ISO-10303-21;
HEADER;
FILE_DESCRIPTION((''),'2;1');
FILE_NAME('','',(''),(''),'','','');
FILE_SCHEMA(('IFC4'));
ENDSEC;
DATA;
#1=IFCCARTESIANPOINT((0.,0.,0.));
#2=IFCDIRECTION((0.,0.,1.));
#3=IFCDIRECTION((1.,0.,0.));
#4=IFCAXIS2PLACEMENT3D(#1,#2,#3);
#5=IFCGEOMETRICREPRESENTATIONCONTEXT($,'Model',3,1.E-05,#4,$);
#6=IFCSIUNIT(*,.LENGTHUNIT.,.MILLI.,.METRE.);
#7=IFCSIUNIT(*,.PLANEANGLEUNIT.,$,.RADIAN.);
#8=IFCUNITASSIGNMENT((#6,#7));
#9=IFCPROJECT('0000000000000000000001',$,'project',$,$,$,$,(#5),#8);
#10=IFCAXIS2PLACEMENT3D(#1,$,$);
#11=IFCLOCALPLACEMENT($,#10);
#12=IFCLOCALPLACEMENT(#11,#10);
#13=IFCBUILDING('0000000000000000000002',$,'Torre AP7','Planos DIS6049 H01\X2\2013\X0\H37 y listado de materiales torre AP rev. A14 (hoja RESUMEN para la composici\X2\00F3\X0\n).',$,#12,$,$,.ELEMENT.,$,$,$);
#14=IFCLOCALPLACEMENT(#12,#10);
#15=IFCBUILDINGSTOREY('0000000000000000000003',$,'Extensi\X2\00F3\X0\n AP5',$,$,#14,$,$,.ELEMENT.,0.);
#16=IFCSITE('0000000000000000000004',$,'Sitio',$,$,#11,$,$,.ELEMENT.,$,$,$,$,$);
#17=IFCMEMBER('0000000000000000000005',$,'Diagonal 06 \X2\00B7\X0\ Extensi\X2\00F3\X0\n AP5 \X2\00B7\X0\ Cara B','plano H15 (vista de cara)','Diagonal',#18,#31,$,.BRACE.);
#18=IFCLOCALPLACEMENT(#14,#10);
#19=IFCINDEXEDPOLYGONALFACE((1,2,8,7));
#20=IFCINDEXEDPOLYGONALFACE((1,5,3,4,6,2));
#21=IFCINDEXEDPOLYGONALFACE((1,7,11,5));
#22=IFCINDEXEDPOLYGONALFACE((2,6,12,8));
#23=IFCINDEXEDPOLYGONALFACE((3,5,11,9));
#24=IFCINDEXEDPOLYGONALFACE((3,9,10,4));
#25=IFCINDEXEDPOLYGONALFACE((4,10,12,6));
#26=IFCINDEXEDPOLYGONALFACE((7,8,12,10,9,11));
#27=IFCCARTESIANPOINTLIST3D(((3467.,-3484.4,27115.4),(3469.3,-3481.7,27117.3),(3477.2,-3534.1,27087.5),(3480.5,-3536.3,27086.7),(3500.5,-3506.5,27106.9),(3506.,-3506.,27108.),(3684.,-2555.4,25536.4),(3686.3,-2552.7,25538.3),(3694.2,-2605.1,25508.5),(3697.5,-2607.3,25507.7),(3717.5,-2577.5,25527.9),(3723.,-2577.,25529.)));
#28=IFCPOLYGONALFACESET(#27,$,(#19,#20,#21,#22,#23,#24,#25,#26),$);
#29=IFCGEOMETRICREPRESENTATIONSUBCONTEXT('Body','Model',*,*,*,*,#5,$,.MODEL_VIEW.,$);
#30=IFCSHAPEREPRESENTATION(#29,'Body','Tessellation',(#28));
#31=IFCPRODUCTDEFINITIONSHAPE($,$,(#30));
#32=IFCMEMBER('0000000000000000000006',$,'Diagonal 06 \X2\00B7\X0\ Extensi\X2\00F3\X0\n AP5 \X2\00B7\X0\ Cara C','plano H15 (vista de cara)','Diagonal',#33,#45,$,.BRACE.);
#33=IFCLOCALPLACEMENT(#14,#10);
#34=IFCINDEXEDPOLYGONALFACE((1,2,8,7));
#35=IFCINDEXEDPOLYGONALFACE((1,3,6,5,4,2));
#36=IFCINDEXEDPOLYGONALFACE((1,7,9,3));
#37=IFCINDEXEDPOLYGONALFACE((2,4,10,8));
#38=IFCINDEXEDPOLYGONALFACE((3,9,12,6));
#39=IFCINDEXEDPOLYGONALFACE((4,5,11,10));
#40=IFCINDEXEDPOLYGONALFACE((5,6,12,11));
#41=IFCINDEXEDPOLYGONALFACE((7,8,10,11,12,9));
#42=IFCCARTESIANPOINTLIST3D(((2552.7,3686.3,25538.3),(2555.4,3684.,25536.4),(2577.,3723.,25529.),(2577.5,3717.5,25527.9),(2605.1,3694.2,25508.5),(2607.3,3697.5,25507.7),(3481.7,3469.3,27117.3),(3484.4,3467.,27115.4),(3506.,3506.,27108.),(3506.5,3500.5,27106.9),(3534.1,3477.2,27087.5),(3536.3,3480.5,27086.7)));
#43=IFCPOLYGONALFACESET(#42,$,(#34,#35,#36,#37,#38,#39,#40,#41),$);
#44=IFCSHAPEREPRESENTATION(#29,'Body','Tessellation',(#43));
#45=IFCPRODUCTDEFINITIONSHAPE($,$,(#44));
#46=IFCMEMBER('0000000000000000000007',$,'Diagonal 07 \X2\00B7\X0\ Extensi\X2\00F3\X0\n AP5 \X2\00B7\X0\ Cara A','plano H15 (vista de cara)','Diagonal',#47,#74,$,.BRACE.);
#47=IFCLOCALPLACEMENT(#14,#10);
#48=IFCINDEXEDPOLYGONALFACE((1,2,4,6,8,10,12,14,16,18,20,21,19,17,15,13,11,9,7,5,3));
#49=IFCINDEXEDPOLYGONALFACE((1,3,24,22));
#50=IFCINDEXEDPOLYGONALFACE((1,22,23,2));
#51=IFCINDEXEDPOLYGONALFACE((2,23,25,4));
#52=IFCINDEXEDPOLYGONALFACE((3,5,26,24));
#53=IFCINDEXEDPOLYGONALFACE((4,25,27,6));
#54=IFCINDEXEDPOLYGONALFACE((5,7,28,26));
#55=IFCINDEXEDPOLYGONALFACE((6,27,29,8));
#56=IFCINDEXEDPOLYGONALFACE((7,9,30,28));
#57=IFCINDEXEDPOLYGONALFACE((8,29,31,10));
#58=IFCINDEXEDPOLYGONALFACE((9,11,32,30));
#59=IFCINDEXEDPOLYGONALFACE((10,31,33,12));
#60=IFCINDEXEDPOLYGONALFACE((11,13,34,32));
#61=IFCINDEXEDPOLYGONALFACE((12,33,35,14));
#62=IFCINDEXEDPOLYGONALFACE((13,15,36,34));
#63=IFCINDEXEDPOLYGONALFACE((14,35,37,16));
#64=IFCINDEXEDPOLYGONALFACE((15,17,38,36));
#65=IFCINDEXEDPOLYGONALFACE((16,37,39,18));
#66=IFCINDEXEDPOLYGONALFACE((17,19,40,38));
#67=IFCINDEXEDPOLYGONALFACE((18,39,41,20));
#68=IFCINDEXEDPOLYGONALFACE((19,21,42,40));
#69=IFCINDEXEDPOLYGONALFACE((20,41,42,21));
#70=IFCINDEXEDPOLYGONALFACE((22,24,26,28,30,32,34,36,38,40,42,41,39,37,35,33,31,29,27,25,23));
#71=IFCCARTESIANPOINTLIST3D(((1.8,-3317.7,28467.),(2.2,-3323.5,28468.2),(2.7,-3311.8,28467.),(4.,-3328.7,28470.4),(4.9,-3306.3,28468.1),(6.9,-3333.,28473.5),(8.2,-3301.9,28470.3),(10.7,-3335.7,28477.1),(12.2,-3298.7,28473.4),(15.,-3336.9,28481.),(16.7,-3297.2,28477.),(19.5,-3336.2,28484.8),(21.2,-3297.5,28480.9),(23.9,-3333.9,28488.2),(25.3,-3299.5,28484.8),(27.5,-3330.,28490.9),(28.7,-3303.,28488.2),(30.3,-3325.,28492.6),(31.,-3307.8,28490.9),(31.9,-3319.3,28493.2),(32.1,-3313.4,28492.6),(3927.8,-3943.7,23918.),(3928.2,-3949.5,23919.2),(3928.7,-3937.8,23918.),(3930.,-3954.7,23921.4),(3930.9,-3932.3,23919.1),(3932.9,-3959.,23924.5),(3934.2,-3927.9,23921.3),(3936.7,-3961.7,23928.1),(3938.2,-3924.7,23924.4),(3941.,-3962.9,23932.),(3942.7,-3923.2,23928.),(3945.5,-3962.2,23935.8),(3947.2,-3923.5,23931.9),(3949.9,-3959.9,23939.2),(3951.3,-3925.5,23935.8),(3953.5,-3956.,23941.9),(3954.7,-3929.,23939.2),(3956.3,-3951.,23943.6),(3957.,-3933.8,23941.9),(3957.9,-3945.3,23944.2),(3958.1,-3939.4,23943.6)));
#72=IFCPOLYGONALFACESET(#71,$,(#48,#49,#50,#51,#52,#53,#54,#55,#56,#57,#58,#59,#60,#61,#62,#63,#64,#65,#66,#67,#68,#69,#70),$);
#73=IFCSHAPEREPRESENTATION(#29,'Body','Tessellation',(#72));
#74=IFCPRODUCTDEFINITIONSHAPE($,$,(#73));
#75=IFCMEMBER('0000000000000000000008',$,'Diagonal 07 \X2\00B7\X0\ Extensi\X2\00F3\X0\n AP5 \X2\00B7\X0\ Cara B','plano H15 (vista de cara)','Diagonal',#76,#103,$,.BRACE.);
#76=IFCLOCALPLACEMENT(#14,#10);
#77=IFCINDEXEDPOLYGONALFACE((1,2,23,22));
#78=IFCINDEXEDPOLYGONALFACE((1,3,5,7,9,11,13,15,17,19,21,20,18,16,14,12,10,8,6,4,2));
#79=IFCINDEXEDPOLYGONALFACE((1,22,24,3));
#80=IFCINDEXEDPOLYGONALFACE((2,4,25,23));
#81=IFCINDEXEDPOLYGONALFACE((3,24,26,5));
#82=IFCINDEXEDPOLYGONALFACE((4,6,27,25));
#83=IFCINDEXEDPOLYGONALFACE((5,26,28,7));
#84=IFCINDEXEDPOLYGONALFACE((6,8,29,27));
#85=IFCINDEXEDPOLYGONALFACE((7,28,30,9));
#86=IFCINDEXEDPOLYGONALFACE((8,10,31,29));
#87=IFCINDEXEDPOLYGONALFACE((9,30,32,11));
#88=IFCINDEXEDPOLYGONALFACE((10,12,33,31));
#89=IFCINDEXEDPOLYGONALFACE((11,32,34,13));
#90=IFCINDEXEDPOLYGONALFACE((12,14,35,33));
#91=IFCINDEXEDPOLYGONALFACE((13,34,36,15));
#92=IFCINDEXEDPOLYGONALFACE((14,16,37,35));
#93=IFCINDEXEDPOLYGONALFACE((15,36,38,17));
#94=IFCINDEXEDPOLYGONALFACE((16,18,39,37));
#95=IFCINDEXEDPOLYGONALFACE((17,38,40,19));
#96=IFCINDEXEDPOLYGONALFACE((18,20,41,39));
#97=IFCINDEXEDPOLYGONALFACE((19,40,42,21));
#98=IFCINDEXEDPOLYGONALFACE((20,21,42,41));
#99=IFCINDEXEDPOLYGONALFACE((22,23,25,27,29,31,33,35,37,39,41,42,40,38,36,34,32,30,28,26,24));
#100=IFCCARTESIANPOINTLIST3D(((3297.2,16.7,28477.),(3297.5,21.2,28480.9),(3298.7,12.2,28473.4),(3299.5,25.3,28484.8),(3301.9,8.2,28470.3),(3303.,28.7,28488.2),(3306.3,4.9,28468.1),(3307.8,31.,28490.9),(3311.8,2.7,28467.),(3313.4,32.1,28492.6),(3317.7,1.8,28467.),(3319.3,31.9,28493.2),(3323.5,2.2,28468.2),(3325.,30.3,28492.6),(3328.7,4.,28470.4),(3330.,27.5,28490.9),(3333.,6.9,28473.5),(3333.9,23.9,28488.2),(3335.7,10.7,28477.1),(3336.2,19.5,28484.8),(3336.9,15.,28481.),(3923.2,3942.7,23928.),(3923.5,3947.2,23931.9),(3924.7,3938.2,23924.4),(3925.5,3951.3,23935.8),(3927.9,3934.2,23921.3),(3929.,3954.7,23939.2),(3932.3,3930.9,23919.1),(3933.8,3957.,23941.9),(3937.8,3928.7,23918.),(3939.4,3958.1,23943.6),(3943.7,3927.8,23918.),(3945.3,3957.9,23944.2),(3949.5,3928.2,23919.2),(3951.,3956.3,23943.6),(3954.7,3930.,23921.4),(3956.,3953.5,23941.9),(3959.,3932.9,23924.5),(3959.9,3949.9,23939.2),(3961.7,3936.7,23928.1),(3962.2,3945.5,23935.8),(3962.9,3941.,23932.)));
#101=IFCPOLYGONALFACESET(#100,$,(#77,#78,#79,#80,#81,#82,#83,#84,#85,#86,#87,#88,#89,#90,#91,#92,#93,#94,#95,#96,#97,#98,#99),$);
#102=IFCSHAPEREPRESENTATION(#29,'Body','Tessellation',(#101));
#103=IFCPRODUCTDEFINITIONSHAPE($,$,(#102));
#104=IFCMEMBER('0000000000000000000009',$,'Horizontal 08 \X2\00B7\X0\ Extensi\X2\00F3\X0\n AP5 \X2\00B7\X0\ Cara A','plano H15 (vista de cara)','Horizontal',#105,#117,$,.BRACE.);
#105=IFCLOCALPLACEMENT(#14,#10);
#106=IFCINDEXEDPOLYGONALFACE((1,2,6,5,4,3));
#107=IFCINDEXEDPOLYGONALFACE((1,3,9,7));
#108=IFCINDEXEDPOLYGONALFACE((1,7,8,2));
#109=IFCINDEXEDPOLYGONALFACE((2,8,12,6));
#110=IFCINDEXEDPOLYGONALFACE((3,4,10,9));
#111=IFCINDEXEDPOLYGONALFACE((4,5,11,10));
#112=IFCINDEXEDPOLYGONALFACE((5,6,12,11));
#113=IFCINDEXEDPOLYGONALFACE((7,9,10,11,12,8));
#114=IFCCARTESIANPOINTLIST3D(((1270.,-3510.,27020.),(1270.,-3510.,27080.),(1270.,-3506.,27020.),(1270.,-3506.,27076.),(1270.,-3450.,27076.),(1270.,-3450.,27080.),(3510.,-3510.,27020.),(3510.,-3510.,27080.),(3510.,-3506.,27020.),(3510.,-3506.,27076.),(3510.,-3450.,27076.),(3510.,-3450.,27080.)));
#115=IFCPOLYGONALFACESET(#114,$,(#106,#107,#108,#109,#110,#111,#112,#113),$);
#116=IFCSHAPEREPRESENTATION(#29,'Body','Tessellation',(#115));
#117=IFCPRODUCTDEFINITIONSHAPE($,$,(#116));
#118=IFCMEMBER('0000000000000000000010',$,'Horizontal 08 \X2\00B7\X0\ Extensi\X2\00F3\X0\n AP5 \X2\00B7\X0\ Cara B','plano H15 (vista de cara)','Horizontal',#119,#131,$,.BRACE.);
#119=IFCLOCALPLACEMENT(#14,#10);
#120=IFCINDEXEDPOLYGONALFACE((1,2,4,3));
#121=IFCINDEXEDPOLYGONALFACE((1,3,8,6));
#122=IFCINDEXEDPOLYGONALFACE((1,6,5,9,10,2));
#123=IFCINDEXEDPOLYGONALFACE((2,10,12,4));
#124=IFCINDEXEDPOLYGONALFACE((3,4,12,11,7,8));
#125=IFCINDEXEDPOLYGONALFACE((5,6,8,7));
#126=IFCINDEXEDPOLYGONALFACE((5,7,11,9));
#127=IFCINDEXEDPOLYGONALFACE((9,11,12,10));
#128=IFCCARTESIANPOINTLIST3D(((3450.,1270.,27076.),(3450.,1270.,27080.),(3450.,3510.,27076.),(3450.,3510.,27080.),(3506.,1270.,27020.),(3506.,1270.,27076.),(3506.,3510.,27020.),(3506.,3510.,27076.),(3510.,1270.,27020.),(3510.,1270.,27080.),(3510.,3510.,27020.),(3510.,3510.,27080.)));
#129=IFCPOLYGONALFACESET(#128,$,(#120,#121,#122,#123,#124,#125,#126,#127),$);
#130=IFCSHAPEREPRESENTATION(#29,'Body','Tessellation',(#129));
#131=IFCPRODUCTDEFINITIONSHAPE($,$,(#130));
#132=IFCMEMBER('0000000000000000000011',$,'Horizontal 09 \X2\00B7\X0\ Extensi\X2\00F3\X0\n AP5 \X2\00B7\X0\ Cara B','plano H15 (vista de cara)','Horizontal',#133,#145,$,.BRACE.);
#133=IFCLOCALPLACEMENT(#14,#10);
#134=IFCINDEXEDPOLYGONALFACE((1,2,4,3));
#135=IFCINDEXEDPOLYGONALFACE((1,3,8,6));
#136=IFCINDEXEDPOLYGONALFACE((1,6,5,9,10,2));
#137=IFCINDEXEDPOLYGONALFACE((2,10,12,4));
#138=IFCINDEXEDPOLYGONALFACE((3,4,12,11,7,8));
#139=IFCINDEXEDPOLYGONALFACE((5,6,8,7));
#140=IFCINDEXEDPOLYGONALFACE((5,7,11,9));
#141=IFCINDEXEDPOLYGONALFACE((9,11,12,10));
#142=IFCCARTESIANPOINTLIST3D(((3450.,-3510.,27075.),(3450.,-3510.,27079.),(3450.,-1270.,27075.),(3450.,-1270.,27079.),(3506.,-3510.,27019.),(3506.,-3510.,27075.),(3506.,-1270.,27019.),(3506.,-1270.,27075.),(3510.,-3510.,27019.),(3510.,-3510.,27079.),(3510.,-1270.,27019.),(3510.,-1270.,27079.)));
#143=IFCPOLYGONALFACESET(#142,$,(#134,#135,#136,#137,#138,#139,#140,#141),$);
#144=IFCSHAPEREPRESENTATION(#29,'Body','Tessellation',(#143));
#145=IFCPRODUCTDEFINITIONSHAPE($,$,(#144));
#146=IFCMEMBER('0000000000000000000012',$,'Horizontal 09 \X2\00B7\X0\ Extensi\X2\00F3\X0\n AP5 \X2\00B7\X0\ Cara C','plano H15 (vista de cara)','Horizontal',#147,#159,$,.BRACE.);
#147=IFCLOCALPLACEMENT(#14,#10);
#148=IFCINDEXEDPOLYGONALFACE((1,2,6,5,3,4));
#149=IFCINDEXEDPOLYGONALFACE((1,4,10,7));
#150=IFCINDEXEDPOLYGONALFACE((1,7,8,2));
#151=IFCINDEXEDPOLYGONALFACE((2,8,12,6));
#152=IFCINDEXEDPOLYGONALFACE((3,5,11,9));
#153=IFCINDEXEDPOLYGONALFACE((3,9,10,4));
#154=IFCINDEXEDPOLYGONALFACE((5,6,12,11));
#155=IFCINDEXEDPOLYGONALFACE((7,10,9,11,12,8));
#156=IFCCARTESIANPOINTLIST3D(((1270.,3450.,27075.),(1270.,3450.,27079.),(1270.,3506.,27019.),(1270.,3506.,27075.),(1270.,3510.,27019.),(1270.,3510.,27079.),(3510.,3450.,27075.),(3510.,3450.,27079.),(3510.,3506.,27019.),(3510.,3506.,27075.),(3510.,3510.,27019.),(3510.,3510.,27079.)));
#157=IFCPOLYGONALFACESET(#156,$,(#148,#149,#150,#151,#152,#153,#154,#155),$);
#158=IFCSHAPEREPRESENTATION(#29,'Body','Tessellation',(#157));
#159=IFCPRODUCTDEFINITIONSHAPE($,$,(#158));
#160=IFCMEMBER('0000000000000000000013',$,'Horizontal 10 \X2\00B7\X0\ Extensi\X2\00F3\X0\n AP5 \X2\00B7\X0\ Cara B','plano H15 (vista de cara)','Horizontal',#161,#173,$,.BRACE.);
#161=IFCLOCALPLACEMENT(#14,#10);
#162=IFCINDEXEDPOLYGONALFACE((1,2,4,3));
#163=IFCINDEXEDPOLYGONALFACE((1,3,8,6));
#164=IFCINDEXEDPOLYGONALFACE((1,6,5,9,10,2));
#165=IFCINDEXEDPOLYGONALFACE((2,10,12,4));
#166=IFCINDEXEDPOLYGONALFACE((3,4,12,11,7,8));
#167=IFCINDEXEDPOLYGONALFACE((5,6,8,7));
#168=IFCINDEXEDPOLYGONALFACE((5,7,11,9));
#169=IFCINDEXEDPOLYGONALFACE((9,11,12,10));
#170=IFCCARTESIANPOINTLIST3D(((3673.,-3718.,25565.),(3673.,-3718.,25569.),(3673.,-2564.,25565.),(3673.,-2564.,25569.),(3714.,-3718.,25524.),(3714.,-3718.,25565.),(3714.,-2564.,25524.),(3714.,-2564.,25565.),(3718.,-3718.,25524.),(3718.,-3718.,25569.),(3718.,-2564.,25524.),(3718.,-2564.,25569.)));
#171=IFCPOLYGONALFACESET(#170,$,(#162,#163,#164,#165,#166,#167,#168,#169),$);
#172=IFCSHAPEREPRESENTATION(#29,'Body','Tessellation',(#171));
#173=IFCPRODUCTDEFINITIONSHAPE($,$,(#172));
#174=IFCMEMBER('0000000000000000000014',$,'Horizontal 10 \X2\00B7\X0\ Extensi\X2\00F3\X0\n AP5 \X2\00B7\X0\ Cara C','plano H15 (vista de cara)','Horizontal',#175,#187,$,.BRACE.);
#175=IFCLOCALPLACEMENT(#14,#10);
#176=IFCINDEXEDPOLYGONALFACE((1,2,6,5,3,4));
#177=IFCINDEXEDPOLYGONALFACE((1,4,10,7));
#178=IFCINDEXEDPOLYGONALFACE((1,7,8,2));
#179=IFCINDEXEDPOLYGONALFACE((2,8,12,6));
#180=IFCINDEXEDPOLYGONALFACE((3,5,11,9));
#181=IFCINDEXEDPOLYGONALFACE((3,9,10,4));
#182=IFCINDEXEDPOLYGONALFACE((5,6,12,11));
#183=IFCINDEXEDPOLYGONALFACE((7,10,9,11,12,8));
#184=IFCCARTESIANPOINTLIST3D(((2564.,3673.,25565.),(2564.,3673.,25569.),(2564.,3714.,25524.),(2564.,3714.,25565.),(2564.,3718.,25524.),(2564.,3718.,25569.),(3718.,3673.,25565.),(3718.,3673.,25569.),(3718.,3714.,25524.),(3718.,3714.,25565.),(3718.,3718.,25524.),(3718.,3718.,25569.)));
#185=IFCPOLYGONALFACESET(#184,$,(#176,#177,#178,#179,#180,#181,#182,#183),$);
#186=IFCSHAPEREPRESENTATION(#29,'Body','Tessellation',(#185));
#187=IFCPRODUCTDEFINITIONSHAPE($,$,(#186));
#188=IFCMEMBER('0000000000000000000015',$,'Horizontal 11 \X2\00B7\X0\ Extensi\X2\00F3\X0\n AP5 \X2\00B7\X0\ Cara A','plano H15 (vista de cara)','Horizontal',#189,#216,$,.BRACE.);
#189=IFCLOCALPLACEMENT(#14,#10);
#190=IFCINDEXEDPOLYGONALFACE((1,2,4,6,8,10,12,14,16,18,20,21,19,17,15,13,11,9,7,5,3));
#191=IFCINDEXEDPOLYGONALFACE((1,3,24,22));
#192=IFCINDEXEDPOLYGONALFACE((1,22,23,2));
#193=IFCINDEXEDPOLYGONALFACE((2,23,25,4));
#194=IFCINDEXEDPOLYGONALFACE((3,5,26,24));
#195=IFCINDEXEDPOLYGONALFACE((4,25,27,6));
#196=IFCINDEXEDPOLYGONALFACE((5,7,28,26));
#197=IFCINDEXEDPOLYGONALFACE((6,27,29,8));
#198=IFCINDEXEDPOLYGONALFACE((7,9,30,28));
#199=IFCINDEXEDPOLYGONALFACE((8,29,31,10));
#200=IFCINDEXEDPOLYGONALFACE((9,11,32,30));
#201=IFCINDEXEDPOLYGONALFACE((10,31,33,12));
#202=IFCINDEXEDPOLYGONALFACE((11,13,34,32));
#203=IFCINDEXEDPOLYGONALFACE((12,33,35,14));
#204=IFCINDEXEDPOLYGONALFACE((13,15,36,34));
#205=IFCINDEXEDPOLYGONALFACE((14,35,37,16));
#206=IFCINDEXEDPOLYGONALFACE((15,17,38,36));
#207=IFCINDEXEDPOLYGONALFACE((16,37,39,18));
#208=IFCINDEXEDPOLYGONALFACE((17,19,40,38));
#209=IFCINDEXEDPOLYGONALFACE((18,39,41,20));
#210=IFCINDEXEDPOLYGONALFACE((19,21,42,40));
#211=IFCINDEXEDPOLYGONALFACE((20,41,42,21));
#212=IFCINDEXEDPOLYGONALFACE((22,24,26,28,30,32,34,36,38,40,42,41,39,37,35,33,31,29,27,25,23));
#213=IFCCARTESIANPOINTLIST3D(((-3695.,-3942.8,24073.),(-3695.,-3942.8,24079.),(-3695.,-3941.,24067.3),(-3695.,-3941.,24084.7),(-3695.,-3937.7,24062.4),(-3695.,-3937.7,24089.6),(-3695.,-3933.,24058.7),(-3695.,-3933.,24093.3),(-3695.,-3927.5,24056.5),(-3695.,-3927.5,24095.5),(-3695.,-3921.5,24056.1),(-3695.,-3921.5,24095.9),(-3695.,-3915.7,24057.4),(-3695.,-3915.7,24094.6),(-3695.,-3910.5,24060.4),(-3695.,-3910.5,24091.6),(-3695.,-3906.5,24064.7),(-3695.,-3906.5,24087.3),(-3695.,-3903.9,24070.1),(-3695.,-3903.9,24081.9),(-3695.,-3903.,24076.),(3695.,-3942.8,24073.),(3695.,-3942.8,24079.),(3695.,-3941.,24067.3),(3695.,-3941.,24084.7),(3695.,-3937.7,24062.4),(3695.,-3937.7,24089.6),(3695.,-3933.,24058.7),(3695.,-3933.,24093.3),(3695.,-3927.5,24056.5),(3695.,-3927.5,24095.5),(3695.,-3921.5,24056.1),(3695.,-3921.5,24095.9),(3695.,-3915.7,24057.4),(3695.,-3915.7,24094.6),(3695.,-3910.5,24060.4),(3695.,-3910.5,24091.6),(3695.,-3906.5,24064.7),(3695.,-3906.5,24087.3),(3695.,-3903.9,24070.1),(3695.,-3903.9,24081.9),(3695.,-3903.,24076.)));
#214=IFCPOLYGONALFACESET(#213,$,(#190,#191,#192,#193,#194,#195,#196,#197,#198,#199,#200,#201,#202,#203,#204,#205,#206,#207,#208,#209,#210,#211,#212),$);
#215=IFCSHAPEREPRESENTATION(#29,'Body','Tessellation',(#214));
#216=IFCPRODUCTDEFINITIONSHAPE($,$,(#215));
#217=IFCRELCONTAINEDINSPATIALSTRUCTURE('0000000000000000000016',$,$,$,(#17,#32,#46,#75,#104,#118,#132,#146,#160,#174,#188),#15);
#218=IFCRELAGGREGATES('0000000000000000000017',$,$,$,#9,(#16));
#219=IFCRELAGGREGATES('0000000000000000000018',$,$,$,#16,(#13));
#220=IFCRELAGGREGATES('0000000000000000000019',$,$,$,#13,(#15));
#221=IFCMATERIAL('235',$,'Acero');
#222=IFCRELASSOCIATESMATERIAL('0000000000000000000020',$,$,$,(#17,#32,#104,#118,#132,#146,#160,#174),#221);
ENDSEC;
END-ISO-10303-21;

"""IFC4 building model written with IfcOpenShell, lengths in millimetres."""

from ifc_helpers import new_model, si_unit, frame, frame_2d, origin, origin_with_axes, place, context, subcontext, project, spatial, circle, l_section, extrude, material, element, save


model = new_model("IFC4")

# Units and contexts
model_context = context("Model", 3, precision=1e-05, world=origin_with_axes())
body_context = subcontext(model_context, "Body", "Model", "MODEL_VIEW")
ifc_project = project(units=[si_unit("LENGTHUNIT", "METRE", prefix="MILLI"), si_unit("PLANEANGLEUNIT", "RADIAN")], contexts=[model_context])

# Site, building, storey
site_placement = place(None, origin())
site = spatial("IfcSite", under=ifc_project, at=site_placement, Name="Sitio", CompositionType="ELEMENT")
building_placement = place(site_placement, origin())
building = spatial("IfcBuilding", under=site, at=building_placement, Name="Torre AP7", Description="Planos DIS6049 H01–H37 y listado de materiales torre AP rev. A14 (hoja RESUMEN para la composición).", CompositionType="ELEMENT")
storey_placement = place(building_placement, origin())
storey = spatial("IfcBuildingStorey", under=building, at=storey_placement, Name="Extensión AP5", CompositionType="ELEMENT", Elevation=0.0)

# Members
ifc_material_1 = material(Name="235", Category="Acero")
for number, where, z_axis, x_axis, name in (
    (1, (3723.0, -2577.0, 25529.0), (-0.117626, -0.503571, 0.855909), (-0.815383, 0.540952, 0.20621), "Diagonal 06 · Extensión AP5 · Cara B"),
    (2, (2577.0, 3723.0, 25529.0), (0.503571, -0.117626, 0.855909), (-0.540952, -0.815383, 0.20621), "Diagonal 06 · Extensión AP5 · Cara C"),
):
    element("IfcMember", number, at=place(storey_placement, frame(where, z_axis=z_axis, x_axis=x_axis)), inside=storey, material=ifc_material_1, Name=name, Description="plano H15 (vista de cara)", ObjectType="Diagonal", PredefinedType="BRACE", context=body_context, shape_type="SweptSolid", body=[
        extrude(l_section(Depth=45.0, Width=45.0, Thickness=4.0, at=frame_2d((22.5, 22.5))), None, (0.0, 0.0, 1.0), 1844.8),
    ])
for number, where, z_axis, x_axis, name in (
    (3, (3943.0, -3943.0, 23931.0), (-0.649847, 0.103618, 0.752969), (-0.237576, 0.913334, -0.330725), "Diagonal 07 · Extensión AP5 · Cara A"),
    (4, (3943.0, 3943.0, 23931.0), (-0.103618, -0.649847, 0.752969), (-0.913334, -0.237576, -0.330725), "Diagonal 07 · Extensión AP5 · Cara B"),
):
    element("IfcMember", number, at=place(storey_placement, frame(where, z_axis=z_axis, x_axis=x_axis)), inside=storey, Name=name, Description="plano H15 (vista de cara)", ObjectType="Diagonal", PredefinedType="BRACE", context=body_context, shape_type="SweptSolid", body=[
        extrude(circle(Radius=20.0), None, (0.0, 0.0, 1.0), 6041.4),
    ])
for number, where, z_axis, x_axis, name in (
    (5, (3510.0, -3510.0, 27080.0), (-1.0, 0.0, 0.0), (0.0, 1.0, 0.0), "Horizontal 08 · Extensión AP5 · Cara A"),
    (6, (3510.0, 3510.0, 27080.0), (0.0, -1.0, 0.0), (-1.0, 0.0, 0.0), "Horizontal 08 · Extensión AP5 · Cara B"),
    (7, (3510.0, -1270.0, 27079.0), (0.0, -1.0, 0.0), (-1.0, 0.0, 0.0), "Horizontal 09 · Extensión AP5 · Cara B"),
    (8, (1270.0, 3510.0, 27079.0), (1.0, 0.0, 0.0), (0.0, -1.0, 0.0), "Horizontal 09 · Extensión AP5 · Cara C"),
):
    element("IfcMember", number, at=place(storey_placement, frame(where, z_axis=z_axis, x_axis=x_axis)), inside=storey, material=ifc_material_1, Name=name, Description="plano H15 (vista de cara)", ObjectType="Horizontal", PredefinedType="BRACE", context=body_context, shape_type="SweptSolid", body=[
        extrude(l_section(Depth=60.0, Width=60.0, Thickness=4.0, at=frame_2d((30.0, 30.0))), None, (0.0, 0.0, 1.0), 2240.0),
    ])
for number, where, z_axis, x_axis, name in (
    (9, (3718.0, -2564.0, 25569.0), (0.0, -1.0, 0.0), (-1.0, 0.0, 0.0), "Horizontal 10 · Extensión AP5 · Cara B"),
    (10, (2564.0, 3718.0, 25569.0), (1.0, 0.0, 0.0), (0.0, -1.0, 0.0), "Horizontal 10 · Extensión AP5 · Cara C"),
):
    element("IfcMember", number, at=place(storey_placement, frame(where, z_axis=z_axis, x_axis=x_axis)), inside=storey, material=ifc_material_1, Name=name, Description="plano H15 (vista de cara)", ObjectType="Horizontal", PredefinedType="BRACE", context=body_context, shape_type="SweptSolid", body=[
        extrude(l_section(Depth=45.0, Width=45.0, Thickness=4.0, at=frame_2d((22.5, 22.5))), None, (0.0, 0.0, 1.0), 1154.0),
    ])
for number, where, z_axis, x_axis, name in (
    (11, (3695.0, -3923.0, 24076.0), (-1.0, 0.0, 0.0), (0.0, 1.0, 0.0), "Horizontal 11 · Extensión AP5 · Cara A"),
):
    element("IfcMember", number, at=place(storey_placement, frame(where, z_axis=z_axis, x_axis=x_axis)), inside=storey, Name=name, Description="plano H15 (vista de cara)", ObjectType="Horizontal", PredefinedType="BRACE", context=body_context, shape_type="SweptSolid", body=[
        extrude(circle(Radius=20.0), None, (0.0, 0.0, 1.0), 7390.0),
    ])

save(model, "model.ifc")
